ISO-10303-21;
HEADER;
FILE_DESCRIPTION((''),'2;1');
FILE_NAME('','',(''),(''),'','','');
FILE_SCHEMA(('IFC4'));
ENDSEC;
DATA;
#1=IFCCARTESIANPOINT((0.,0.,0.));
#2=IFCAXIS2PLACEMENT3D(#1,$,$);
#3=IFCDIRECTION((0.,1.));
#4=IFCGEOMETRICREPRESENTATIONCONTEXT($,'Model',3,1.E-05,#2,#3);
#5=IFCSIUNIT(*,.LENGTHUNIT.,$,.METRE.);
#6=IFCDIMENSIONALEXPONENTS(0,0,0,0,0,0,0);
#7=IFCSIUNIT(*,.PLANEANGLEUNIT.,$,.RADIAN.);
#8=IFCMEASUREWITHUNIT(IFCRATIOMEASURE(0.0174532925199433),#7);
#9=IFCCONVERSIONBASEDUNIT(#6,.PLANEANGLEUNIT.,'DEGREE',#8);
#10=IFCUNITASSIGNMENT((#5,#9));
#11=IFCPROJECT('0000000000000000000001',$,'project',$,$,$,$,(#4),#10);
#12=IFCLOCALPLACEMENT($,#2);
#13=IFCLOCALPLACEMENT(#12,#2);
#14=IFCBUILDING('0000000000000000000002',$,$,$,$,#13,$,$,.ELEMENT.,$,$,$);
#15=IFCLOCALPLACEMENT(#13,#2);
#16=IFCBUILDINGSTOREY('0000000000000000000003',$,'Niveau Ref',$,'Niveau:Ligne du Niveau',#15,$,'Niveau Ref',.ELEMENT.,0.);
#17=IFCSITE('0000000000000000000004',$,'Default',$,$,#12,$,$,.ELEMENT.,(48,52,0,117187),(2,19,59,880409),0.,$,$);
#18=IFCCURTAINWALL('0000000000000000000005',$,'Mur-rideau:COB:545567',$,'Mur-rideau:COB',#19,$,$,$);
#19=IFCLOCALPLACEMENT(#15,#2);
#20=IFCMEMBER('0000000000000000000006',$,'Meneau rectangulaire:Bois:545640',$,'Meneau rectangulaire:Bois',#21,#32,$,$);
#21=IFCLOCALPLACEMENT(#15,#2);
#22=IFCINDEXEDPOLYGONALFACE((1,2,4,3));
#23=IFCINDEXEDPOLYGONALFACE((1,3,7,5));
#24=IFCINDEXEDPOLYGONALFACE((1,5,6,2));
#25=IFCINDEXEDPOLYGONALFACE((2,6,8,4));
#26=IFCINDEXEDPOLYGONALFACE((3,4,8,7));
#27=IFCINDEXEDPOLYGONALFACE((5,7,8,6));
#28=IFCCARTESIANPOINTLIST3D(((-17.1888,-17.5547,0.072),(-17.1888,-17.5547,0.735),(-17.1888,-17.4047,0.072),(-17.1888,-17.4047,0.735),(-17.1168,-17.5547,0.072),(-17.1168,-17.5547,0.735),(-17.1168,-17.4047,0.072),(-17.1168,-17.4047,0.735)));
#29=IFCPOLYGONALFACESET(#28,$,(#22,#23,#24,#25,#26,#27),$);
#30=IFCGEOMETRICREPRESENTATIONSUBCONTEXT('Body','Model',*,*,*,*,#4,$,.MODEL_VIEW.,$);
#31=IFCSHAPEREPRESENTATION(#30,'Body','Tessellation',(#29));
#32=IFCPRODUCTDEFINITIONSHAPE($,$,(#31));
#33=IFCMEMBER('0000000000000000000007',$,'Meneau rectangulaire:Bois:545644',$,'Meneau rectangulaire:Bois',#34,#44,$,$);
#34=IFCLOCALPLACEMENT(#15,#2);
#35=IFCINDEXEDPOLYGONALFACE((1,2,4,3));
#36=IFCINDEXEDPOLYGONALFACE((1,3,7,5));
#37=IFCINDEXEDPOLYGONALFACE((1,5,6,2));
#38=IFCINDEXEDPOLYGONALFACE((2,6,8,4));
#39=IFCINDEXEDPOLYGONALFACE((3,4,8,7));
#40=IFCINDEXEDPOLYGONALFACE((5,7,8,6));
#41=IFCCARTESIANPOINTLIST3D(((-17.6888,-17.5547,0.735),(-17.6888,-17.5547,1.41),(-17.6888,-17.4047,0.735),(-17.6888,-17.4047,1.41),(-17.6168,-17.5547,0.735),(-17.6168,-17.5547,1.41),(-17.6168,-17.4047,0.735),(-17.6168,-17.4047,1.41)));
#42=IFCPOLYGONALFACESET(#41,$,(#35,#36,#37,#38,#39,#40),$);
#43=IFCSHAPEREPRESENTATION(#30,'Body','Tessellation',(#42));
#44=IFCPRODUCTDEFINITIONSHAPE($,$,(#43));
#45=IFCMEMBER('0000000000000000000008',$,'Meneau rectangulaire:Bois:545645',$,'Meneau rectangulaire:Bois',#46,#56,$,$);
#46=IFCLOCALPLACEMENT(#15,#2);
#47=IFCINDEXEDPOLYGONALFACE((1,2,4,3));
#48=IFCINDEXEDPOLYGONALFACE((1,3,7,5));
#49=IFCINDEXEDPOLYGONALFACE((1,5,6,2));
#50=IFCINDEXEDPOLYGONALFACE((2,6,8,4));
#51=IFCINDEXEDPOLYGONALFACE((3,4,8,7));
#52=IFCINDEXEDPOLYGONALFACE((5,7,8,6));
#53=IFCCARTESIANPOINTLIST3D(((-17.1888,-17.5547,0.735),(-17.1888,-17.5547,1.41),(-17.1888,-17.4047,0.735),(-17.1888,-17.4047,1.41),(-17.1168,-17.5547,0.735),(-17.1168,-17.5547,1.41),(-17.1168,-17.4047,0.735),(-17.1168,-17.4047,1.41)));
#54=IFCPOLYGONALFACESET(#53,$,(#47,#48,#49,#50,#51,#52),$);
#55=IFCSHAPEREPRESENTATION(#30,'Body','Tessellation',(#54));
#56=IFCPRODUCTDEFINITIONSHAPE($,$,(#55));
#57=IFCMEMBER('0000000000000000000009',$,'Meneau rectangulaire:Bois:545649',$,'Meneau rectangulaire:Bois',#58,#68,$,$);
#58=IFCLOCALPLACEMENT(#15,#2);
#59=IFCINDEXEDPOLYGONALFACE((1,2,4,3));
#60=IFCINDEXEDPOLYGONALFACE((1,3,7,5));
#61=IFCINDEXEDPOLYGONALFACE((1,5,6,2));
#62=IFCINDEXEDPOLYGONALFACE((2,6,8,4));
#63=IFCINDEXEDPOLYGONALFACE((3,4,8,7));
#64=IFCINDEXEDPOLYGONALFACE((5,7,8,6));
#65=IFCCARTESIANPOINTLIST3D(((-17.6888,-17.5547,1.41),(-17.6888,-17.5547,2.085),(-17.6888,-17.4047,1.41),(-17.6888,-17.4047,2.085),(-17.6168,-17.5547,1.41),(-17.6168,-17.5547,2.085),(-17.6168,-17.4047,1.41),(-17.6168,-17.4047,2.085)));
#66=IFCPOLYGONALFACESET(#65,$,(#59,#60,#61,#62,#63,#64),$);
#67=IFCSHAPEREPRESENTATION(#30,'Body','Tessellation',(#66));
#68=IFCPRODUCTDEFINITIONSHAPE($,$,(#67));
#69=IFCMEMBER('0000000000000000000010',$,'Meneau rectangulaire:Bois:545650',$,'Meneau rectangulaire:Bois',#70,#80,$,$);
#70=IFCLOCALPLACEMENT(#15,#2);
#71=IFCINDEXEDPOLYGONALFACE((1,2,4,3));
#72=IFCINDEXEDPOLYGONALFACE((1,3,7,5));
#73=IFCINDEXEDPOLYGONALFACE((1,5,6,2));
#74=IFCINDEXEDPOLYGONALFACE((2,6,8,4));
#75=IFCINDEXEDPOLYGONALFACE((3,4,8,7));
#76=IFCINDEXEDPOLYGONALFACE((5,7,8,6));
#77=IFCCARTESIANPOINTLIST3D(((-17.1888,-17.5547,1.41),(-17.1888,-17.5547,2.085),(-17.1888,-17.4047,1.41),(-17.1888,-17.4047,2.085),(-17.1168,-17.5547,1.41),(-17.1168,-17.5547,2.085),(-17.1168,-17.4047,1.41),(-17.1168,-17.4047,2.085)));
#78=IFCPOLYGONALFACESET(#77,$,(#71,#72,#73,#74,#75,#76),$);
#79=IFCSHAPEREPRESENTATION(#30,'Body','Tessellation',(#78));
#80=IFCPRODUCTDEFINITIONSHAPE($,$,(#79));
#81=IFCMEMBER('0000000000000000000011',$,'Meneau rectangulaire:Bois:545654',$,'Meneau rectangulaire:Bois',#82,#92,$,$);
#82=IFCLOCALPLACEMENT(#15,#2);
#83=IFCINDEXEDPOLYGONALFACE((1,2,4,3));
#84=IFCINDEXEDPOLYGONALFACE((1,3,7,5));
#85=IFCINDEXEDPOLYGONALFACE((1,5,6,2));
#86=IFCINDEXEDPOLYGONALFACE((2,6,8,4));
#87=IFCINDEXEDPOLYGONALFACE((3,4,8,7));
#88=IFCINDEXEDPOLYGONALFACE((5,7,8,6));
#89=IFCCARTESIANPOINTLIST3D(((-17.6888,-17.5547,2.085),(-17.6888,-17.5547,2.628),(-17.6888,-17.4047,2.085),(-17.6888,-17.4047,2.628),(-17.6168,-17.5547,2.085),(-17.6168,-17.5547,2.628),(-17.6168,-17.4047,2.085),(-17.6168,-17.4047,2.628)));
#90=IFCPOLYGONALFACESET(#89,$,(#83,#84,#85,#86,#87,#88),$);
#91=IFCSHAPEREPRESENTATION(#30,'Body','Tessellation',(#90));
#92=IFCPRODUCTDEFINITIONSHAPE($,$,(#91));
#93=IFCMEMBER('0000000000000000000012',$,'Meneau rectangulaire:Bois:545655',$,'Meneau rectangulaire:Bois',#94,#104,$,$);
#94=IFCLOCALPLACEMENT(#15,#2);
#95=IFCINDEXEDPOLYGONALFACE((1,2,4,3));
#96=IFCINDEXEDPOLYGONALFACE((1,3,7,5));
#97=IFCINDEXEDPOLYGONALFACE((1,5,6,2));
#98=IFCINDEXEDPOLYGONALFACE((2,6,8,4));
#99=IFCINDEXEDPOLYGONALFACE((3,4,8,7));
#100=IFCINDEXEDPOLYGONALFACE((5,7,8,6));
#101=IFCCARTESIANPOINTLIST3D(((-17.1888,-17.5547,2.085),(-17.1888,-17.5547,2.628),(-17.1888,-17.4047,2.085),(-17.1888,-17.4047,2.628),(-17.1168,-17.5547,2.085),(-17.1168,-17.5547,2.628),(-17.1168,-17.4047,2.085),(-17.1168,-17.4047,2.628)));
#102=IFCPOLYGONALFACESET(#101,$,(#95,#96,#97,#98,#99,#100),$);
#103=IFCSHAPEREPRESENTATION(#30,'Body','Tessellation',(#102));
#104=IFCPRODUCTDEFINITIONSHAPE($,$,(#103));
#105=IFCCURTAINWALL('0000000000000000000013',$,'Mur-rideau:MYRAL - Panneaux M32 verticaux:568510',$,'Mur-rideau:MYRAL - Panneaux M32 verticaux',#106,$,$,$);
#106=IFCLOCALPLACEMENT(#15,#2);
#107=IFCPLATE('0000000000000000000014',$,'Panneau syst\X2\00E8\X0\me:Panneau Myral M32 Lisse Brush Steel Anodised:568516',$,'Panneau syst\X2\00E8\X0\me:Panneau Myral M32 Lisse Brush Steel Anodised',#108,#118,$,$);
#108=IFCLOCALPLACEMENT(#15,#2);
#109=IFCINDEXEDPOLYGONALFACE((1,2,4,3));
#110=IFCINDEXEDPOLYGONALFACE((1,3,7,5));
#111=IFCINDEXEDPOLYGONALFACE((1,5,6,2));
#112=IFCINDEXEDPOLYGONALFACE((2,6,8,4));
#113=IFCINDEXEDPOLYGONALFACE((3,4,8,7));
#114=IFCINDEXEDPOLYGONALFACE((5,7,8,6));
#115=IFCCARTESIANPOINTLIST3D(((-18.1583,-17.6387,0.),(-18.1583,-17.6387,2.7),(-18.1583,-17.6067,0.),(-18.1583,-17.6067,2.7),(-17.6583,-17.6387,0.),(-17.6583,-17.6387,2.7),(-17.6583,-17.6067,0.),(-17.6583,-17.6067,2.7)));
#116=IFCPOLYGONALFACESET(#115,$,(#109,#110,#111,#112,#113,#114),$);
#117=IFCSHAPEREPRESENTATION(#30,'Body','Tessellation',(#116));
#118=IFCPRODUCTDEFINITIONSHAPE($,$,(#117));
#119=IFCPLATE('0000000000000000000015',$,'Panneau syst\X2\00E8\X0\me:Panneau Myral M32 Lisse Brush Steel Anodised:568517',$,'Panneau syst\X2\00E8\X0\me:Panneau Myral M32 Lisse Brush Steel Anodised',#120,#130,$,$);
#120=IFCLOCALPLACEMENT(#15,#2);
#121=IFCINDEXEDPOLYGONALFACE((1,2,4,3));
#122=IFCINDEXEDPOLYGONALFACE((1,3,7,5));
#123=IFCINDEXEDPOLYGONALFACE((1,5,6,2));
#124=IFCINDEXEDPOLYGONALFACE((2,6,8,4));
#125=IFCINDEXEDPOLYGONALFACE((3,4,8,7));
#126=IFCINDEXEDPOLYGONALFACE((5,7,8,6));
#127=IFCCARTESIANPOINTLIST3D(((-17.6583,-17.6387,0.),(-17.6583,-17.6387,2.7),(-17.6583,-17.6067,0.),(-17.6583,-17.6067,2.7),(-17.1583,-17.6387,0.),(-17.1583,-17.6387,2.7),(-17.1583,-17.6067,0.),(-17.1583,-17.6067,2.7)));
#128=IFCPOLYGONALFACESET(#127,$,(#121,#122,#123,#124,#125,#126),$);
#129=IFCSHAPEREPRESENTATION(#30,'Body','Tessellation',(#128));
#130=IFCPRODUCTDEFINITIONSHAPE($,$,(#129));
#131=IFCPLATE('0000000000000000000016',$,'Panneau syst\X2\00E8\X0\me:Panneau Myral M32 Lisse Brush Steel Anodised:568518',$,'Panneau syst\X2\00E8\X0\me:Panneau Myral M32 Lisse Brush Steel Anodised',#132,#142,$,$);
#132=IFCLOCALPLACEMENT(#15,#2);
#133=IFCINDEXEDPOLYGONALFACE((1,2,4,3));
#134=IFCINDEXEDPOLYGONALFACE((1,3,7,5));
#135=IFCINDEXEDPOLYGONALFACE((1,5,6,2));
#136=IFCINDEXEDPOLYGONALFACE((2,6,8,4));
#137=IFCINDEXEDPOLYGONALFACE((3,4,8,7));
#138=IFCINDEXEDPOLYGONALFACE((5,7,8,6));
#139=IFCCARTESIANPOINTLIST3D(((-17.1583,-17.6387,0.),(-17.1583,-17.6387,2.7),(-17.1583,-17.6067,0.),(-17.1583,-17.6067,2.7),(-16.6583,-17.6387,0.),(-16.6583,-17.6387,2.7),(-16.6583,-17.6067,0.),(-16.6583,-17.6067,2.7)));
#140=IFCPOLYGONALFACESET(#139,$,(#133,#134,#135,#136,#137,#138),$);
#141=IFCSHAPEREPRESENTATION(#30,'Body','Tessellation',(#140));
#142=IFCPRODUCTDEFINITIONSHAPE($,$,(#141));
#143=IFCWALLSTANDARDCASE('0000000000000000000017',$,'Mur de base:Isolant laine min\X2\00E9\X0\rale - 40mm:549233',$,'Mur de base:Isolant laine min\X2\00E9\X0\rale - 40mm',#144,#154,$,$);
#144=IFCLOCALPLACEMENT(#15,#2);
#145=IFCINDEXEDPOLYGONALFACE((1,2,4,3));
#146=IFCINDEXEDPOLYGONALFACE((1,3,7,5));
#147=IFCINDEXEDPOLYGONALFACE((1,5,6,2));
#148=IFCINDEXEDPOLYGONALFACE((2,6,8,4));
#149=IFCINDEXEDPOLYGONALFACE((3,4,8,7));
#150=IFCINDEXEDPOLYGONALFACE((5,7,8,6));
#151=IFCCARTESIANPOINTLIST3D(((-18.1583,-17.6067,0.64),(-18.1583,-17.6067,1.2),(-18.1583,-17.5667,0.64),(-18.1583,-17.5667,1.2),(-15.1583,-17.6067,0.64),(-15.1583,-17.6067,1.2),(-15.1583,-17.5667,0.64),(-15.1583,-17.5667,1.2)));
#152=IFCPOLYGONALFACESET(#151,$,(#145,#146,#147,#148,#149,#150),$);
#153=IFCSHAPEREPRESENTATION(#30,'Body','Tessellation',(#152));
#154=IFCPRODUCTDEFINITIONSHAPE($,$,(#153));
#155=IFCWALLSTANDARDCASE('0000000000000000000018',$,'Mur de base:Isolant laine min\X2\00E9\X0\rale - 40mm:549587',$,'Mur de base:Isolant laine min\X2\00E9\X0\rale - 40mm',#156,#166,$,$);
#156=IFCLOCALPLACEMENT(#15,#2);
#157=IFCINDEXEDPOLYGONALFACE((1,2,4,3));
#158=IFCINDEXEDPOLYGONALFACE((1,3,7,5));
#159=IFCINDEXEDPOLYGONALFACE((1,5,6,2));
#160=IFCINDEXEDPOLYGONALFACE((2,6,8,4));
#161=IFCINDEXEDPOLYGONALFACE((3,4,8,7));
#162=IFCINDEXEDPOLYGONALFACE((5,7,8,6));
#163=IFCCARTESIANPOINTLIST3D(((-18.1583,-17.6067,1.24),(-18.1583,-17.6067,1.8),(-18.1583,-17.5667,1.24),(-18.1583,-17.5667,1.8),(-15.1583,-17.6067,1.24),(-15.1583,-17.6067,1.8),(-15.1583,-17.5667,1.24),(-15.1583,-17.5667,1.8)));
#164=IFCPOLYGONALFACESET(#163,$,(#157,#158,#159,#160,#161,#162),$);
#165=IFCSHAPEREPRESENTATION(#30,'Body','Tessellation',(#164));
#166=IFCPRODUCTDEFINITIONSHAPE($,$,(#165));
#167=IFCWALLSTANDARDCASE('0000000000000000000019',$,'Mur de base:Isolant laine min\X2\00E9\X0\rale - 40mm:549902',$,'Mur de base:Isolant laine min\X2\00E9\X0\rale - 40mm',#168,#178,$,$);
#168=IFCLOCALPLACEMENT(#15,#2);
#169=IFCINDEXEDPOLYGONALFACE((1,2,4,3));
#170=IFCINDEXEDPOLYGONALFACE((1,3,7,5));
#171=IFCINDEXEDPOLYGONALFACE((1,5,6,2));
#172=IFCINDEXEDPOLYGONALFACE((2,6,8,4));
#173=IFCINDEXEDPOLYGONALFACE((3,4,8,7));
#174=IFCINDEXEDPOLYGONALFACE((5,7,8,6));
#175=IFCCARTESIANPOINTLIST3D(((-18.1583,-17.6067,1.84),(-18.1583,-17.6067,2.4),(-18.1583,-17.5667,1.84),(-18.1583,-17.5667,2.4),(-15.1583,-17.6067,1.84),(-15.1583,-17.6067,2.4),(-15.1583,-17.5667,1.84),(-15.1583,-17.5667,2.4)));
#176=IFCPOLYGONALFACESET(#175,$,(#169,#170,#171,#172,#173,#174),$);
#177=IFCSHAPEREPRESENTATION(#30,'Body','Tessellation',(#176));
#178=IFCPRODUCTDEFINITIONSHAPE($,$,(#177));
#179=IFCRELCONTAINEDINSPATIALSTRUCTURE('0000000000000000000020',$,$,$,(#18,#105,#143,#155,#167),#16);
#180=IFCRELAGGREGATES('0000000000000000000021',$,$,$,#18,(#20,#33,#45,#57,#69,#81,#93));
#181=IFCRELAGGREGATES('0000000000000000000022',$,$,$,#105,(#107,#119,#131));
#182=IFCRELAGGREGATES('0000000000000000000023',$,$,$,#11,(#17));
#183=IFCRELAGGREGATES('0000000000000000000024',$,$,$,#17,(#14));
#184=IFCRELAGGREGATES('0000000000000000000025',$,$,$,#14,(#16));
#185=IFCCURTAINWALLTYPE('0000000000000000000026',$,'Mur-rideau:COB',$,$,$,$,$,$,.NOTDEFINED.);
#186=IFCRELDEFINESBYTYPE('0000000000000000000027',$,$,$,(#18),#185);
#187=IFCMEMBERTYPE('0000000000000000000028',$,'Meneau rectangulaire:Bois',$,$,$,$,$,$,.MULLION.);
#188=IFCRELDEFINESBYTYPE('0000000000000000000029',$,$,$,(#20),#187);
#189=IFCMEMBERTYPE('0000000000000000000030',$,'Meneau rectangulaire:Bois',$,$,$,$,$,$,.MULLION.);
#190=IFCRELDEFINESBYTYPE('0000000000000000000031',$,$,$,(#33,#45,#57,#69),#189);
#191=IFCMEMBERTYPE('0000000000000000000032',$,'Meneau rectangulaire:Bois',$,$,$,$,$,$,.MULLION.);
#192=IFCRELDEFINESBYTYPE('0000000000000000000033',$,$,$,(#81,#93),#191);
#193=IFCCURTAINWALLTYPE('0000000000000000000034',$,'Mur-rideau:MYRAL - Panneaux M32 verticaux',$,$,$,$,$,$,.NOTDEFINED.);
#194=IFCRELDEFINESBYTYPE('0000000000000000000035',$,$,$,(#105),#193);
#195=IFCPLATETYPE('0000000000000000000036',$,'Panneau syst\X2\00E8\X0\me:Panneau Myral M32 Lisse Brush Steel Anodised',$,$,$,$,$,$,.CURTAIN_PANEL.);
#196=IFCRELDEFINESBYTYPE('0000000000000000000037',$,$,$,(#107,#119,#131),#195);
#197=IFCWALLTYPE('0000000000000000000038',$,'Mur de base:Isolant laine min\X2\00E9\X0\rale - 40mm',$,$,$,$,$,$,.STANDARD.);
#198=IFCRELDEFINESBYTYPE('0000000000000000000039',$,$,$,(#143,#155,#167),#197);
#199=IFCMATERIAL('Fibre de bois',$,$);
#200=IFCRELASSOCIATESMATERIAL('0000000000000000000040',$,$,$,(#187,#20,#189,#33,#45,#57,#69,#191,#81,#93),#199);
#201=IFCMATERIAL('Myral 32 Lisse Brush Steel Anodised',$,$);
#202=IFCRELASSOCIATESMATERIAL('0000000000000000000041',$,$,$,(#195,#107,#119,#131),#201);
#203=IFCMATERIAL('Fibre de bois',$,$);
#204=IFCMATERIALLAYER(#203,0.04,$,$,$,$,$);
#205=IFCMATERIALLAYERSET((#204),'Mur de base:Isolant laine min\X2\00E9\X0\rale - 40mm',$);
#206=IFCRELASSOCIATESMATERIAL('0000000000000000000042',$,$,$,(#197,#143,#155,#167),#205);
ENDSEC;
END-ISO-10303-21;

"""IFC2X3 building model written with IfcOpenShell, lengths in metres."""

from ifc_helpers import new_model, entity, si_unit, converted_unit, direction, frame, frame_2d, origin, origin_2d_with_axis, place, context, subcontext, project, spatial, rectangle, extrude, source, transform, mapped, material, layer, layer_set, layer_usage, type_object, type_shapes, element, aggregate, save


model = new_model("IFC2X3")

# Units and contexts
model_context = context("Model", 3, precision=1e-05, world=origin(), true_north=direction((0.0, 1.0)))
body_context = subcontext(model_context, "Body", "Model", "MODEL_VIEW")
ifc_project = project(units=[si_unit("LENGTHUNIT", "METRE"), converted_unit("PLANEANGLEUNIT", "DEGREE", entity("IfcRatioMeasure", 0.0174532925199433), si_unit("PLANEANGLEUNIT", "RADIAN"), dimensions=[0, 0, 0, 0, 0, 0, 0])], contexts=[model_context])

# Site, building, storey
site_placement = place(None, origin())
site = spatial("IfcSite", under=ifc_project, at=site_placement, Name="Default", CompositionType="ELEMENT", RefLatitude=(48, 52, 0, 117187), RefLongitude=(2, 19, 59, 880409), RefElevation=0.0)
building_placement = place(site_placement, origin())
building = spatial("IfcBuilding", under=site, at=building_placement, CompositionType="ELEMENT")
storey_placement = place(building_placement, origin())
storey = spatial("IfcBuildingStorey", under=building, at=storey_placement, Name="Niveau Ref", ObjectType="Niveau:Ligne du Niveau", LongName="Niveau Ref", CompositionType="ELEMENT", Elevation=0.0)

# Curtain wall, members
curtain_wall_type_1 = type_object("IfcCurtainWallType", Name="Mur-rideau:COB", PredefinedType="NOTDEFINED")
curtain_wall_1_placement = place(storey_placement, origin())
curtain_wall_1 = element("IfcCurtainWall", 1, at=curtain_wall_1_placement, inside=storey, type_object=curtain_wall_type_1, Name="Mur-rideau:COB:545567", ObjectType="Mur-rideau:COB")
ifc_material_1 = material(Name="Fibre de bois")
member_type_1 = type_object("IfcMemberType", Name="Meneau rectangulaire:Bois", PredefinedType="MULLION", material=ifc_material_1)
shared_shape_1 = source(origin(), body_context, "Body", "SweptSolid", [
    extrude(rectangle(XDim=0.15, YDim=0.072, at=origin_2d_with_axis()), frame((-0.024, 0.0, -0.663), z_axis=(0.0, 0.0, 1.0), x_axis=(0.0, -1.0, 0.0)), (0.0, 0.0, 1.0), 0.663),
])
type_shapes(member_type_1, [shared_shape_1])
member_1_placement = place(storey_placement, frame((-17.1288, -17.4797, 0.072), z_axis=(0.0, 0.0, -1.0), x_axis=(1.0, 0.0, 0.0)))
member_1 = element("IfcMember", 2, at=member_1_placement, type_object=member_type_1, material=ifc_material_1, Name="Meneau rectangulaire:Bois:545640", ObjectType="Meneau rectangulaire:Bois", context=body_context, shape_type="MappedRepresentation", body=[
    mapped(shared_shape_1, transform((0.0, 0.0, 0.0), scale=1.0)),
])
member_type_2 = type_object("IfcMemberType", Name="Meneau rectangulaire:Bois", PredefinedType="MULLION", material=ifc_material_1)
shared_shape_2 = source(origin(), body_context, "Body", "SweptSolid", [
    extrude(rectangle(XDim=0.15, YDim=0.072, at=origin_2d_with_axis()), frame((-0.024, 0.0, -0.675), z_axis=(0.0, 0.0, 1.0), x_axis=(0.0, -1.0, 0.0)), (0.0, 0.0, 1.0), 0.675),
])
type_shapes(member_type_2, [shared_shape_2])
member_2_placement = place(storey_placement, frame((-17.6288, -17.4797, 0.735), z_axis=(0.0, 0.0, -1.0), x_axis=(1.0, 0.0, 0.0)))
member_2 = element("IfcMember", 3, at=member_2_placement, type_object=member_type_2, material=ifc_material_1, Name="Meneau rectangulaire:Bois:545644", ObjectType="Meneau rectangulaire:Bois", context=body_context, shape_type="MappedRepresentation", body=[
    mapped(shared_shape_2, transform((0.0, 0.0, 0.0), scale=1.0)),
])
member_3_placement = place(storey_placement, frame((-17.1288, -17.4797, 0.735), z_axis=(0.0, 0.0, -1.0), x_axis=(1.0, 0.0, 0.0)))
member_3 = element("IfcMember", 4, at=member_3_placement, type_object=member_type_2, material=ifc_material_1, Name="Meneau rectangulaire:Bois:545645", ObjectType="Meneau rectangulaire:Bois", context=body_context, shape_type="MappedRepresentation", body=[
    mapped(shared_shape_2, transform((0.0, 0.0, 0.0), scale=1.0)),
])
member_4_placement = place(storey_placement, frame((-17.6288, -17.4797, 1.41), z_axis=(0.0, 0.0, -1.0), x_axis=(1.0, 0.0, 0.0)))
member_4 = element("IfcMember", 5, at=member_4_placement, type_object=member_type_2, material=ifc_material_1, Name="Meneau rectangulaire:Bois:545649", ObjectType="Meneau rectangulaire:Bois", context=body_context, shape_type="MappedRepresentation", body=[
    mapped(shared_shape_2, transform((0.0, 0.0, 0.0), scale=1.0)),
])
member_5_placement = place(storey_placement, frame((-17.1288, -17.4797, 1.41), z_axis=(0.0, 0.0, -1.0), x_axis=(1.0, 0.0, 0.0)))
member_5 = element("IfcMember", 6, at=member_5_placement, type_object=member_type_2, material=ifc_material_1, Name="Meneau rectangulaire:Bois:545650", ObjectType="Meneau rectangulaire:Bois", context=body_context, shape_type="MappedRepresentation", body=[
    mapped(shared_shape_2, transform((0.0, 0.0, 0.0), scale=1.0)),
])
member_type_3 = type_object("IfcMemberType", Name="Meneau rectangulaire:Bois", PredefinedType="MULLION", material=ifc_material_1)
shared_shape_3 = source(origin(), body_context, "Body", "SweptSolid", [
    extrude(rectangle(XDim=0.15, YDim=0.072, at=origin_2d_with_axis()), frame((-0.024, 0.0, -0.543), z_axis=(0.0, 0.0, 1.0), x_axis=(0.0, -1.0, 0.0)), (0.0, 0.0, 1.0), 0.543),
])
type_shapes(member_type_3, [shared_shape_3])
member_6_placement = place(storey_placement, frame((-17.6288, -17.4797, 2.085), z_axis=(0.0, 0.0, -1.0), x_axis=(1.0, 0.0, 0.0)))
member_6 = element("IfcMember", 7, at=member_6_placement, type_object=member_type_3, material=ifc_material_1, Name="Meneau rectangulaire:Bois:545654", ObjectType="Meneau rectangulaire:Bois", context=body_context, shape_type="MappedRepresentation", body=[
    mapped(shared_shape_3, transform((0.0, 0.0, 0.0), scale=1.0)),
])
member_7_placement = place(storey_placement, frame((-17.1288, -17.4797, 2.085), z_axis=(0.0, 0.0, -1.0), x_axis=(1.0, 0.0, 0.0)))
member_7 = element("IfcMember", 8, at=member_7_placement, type_object=member_type_3, material=ifc_material_1, Name="Meneau rectangulaire:Bois:545655", ObjectType="Meneau rectangulaire:Bois", context=body_context, shape_type="MappedRepresentation", body=[
    mapped(shared_shape_3, transform((0.0, 0.0, 0.0), scale=1.0)),
])
aggregate(curtain_wall_1, [member_1, member_2, member_3, member_4, member_5, member_6, member_7])

# Curtain wall, plates
curtain_wall_type_2 = type_object("IfcCurtainWallType", Name="Mur-rideau:MYRAL - Panneaux M32 verticaux", PredefinedType="NOTDEFINED")
curtain_wall_2_placement = place(storey_placement, origin())
curtain_wall_2 = element("IfcCurtainWall", 9, at=curtain_wall_2_placement, inside=storey, type_object=curtain_wall_type_2, Name="Mur-rideau:MYRAL - Panneaux M32 verticaux:568510", ObjectType="Mur-rideau:MYRAL - Panneaux M32 verticaux")
ifc_material_2 = material(Name="Myral 32 Lisse Brush Steel Anodised")
plate_type = type_object("IfcPlateType", Name="Panneau système:Panneau Myral M32 Lisse Brush Steel Anodised", PredefinedType="CURTAIN_PANEL", material=ifc_material_2)
shared_shape_4 = source(origin(), body_context, "Body", "SweptSolid", [
    extrude(rectangle(XDim=0.032, YDim=0.5, at=origin_2d_with_axis()), frame((0.0, -0.016, 0.0), z_axis=(0.0, 0.0, 1.0), x_axis=(0.0, 1.0, 0.0)), (0.0, 0.0, 1.0), 2.7),
])
type_shapes(plate_type, [shared_shape_4])
plate_1_placement = place(curtain_wall_2_placement, frame((-17.9083, -17.6067, 0.0)))
plate_1 = element("IfcPlate", 10, at=plate_1_placement, type_object=plate_type, material=ifc_material_2, Name="Panneau système:Panneau Myral M32 Lisse Brush Steel Anodised:568516", ObjectType="Panneau système:Panneau Myral M32 Lisse Brush Steel Anodised", context=body_context, shape_type="MappedRepresentation", body=[
    mapped(shared_shape_4, transform((0.0, 0.0, 0.0), scale=1.0)),
])
plate_2_placement = place(curtain_wall_2_placement, frame((-17.4083, -17.6067, 0.0)))
plate_2 = element("IfcPlate", 11, at=plate_2_placement, type_object=plate_type, material=ifc_material_2, Name="Panneau système:Panneau Myral M32 Lisse Brush Steel Anodised:568517", ObjectType="Panneau système:Panneau Myral M32 Lisse Brush Steel Anodised", context=body_context, shape_type="MappedRepresentation", body=[
    mapped(shared_shape_4, transform((0.0, 0.0, 0.0), scale=1.0)),
])
plate_3_placement = place(curtain_wall_2_placement, frame((-16.9083, -17.6067, 0.0)))
plate_3 = element("IfcPlate", 12, at=plate_3_placement, type_object=plate_type, material=ifc_material_2, Name="Panneau système:Panneau Myral M32 Lisse Brush Steel Anodised:568518", ObjectType="Panneau système:Panneau Myral M32 Lisse Brush Steel Anodised", context=body_context, shape_type="MappedRepresentation", body=[
    mapped(shared_shape_4, transform((0.0, 0.0, 0.0), scale=1.0)),
])
aggregate(curtain_wall_2, [plate_1, plate_2, plate_3])

# Walls
ifc_material_3 = material(Name="Fibre de bois")
ifc_layer = layer(ifc_material_3, 0.04)
ifc_layer_set = layer_set([ifc_layer], Name="Mur de base:Isolant laine minérale - 40mm")
ifc_layer_usage_1 = layer_usage(ifc_layer_set, "AXIS2", "NEGATIVE", 0.02)
wall_type = type_object("IfcWallType", Name="Mur de base:Isolant laine minérale - 40mm", PredefinedType="STANDARD", material=ifc_layer_set)
wall_1_placement = place(storey_placement, frame((-18.1583, -17.5867, 0.64)))
element("IfcWallStandardCase", 13, at=wall_1_placement, inside=storey, type_object=wall_type, material=ifc_layer_usage_1, Name="Mur de base:Isolant laine minérale - 40mm:549233", ObjectType="Mur de base:Isolant laine minérale - 40mm", context=body_context, shape_type="SweptSolid", body=[
    extrude(rectangle(XDim=3.0, YDim=0.04, at=frame_2d((1.5, 0.0), x_axis=(-1.0, 0.0))), origin(), (0.0, 0.0, 1.0), 0.56),
])
ifc_layer_usage_2 = layer_usage(ifc_layer_set, "AXIS2", "NEGATIVE", 0.02)
wall_2_placement = place(storey_placement, frame((-18.1583, -17.5867, 1.24)))
element("IfcWallStandardCase", 14, at=wall_2_placement, inside=storey, type_object=wall_type, material=ifc_layer_usage_2, Name="Mur de base:Isolant laine minérale - 40mm:549587", ObjectType="Mur de base:Isolant laine minérale - 40mm", context=body_context, shape_type="SweptSolid", body=[
    extrude(rectangle(XDim=3.0, YDim=0.04, at=frame_2d((1.5, 0.0), x_axis=(-1.0, 0.0))), origin(), (0.0, 0.0, 1.0), 0.56),
])
ifc_layer_usage_3 = layer_usage(ifc_layer_set, "AXIS2", "NEGATIVE", 0.02)
wall_3_placement = place(storey_placement, frame((-18.1583, -17.5867, 1.84)))
element("IfcWallStandardCase", 15, at=wall_3_placement, inside=storey, type_object=wall_type, material=ifc_layer_usage_3, Name="Mur de base:Isolant laine minérale - 40mm:549902", ObjectType="Mur de base:Isolant laine minérale - 40mm", context=body_context, shape_type="SweptSolid", body=[
    extrude(rectangle(XDim=3.0, YDim=0.04, at=frame_2d((1.5, 0.0), x_axis=(-1.0, 0.0))), origin(), (0.0, 0.0, 1.0), 0.56),
])

save(model, "model.ifc")
